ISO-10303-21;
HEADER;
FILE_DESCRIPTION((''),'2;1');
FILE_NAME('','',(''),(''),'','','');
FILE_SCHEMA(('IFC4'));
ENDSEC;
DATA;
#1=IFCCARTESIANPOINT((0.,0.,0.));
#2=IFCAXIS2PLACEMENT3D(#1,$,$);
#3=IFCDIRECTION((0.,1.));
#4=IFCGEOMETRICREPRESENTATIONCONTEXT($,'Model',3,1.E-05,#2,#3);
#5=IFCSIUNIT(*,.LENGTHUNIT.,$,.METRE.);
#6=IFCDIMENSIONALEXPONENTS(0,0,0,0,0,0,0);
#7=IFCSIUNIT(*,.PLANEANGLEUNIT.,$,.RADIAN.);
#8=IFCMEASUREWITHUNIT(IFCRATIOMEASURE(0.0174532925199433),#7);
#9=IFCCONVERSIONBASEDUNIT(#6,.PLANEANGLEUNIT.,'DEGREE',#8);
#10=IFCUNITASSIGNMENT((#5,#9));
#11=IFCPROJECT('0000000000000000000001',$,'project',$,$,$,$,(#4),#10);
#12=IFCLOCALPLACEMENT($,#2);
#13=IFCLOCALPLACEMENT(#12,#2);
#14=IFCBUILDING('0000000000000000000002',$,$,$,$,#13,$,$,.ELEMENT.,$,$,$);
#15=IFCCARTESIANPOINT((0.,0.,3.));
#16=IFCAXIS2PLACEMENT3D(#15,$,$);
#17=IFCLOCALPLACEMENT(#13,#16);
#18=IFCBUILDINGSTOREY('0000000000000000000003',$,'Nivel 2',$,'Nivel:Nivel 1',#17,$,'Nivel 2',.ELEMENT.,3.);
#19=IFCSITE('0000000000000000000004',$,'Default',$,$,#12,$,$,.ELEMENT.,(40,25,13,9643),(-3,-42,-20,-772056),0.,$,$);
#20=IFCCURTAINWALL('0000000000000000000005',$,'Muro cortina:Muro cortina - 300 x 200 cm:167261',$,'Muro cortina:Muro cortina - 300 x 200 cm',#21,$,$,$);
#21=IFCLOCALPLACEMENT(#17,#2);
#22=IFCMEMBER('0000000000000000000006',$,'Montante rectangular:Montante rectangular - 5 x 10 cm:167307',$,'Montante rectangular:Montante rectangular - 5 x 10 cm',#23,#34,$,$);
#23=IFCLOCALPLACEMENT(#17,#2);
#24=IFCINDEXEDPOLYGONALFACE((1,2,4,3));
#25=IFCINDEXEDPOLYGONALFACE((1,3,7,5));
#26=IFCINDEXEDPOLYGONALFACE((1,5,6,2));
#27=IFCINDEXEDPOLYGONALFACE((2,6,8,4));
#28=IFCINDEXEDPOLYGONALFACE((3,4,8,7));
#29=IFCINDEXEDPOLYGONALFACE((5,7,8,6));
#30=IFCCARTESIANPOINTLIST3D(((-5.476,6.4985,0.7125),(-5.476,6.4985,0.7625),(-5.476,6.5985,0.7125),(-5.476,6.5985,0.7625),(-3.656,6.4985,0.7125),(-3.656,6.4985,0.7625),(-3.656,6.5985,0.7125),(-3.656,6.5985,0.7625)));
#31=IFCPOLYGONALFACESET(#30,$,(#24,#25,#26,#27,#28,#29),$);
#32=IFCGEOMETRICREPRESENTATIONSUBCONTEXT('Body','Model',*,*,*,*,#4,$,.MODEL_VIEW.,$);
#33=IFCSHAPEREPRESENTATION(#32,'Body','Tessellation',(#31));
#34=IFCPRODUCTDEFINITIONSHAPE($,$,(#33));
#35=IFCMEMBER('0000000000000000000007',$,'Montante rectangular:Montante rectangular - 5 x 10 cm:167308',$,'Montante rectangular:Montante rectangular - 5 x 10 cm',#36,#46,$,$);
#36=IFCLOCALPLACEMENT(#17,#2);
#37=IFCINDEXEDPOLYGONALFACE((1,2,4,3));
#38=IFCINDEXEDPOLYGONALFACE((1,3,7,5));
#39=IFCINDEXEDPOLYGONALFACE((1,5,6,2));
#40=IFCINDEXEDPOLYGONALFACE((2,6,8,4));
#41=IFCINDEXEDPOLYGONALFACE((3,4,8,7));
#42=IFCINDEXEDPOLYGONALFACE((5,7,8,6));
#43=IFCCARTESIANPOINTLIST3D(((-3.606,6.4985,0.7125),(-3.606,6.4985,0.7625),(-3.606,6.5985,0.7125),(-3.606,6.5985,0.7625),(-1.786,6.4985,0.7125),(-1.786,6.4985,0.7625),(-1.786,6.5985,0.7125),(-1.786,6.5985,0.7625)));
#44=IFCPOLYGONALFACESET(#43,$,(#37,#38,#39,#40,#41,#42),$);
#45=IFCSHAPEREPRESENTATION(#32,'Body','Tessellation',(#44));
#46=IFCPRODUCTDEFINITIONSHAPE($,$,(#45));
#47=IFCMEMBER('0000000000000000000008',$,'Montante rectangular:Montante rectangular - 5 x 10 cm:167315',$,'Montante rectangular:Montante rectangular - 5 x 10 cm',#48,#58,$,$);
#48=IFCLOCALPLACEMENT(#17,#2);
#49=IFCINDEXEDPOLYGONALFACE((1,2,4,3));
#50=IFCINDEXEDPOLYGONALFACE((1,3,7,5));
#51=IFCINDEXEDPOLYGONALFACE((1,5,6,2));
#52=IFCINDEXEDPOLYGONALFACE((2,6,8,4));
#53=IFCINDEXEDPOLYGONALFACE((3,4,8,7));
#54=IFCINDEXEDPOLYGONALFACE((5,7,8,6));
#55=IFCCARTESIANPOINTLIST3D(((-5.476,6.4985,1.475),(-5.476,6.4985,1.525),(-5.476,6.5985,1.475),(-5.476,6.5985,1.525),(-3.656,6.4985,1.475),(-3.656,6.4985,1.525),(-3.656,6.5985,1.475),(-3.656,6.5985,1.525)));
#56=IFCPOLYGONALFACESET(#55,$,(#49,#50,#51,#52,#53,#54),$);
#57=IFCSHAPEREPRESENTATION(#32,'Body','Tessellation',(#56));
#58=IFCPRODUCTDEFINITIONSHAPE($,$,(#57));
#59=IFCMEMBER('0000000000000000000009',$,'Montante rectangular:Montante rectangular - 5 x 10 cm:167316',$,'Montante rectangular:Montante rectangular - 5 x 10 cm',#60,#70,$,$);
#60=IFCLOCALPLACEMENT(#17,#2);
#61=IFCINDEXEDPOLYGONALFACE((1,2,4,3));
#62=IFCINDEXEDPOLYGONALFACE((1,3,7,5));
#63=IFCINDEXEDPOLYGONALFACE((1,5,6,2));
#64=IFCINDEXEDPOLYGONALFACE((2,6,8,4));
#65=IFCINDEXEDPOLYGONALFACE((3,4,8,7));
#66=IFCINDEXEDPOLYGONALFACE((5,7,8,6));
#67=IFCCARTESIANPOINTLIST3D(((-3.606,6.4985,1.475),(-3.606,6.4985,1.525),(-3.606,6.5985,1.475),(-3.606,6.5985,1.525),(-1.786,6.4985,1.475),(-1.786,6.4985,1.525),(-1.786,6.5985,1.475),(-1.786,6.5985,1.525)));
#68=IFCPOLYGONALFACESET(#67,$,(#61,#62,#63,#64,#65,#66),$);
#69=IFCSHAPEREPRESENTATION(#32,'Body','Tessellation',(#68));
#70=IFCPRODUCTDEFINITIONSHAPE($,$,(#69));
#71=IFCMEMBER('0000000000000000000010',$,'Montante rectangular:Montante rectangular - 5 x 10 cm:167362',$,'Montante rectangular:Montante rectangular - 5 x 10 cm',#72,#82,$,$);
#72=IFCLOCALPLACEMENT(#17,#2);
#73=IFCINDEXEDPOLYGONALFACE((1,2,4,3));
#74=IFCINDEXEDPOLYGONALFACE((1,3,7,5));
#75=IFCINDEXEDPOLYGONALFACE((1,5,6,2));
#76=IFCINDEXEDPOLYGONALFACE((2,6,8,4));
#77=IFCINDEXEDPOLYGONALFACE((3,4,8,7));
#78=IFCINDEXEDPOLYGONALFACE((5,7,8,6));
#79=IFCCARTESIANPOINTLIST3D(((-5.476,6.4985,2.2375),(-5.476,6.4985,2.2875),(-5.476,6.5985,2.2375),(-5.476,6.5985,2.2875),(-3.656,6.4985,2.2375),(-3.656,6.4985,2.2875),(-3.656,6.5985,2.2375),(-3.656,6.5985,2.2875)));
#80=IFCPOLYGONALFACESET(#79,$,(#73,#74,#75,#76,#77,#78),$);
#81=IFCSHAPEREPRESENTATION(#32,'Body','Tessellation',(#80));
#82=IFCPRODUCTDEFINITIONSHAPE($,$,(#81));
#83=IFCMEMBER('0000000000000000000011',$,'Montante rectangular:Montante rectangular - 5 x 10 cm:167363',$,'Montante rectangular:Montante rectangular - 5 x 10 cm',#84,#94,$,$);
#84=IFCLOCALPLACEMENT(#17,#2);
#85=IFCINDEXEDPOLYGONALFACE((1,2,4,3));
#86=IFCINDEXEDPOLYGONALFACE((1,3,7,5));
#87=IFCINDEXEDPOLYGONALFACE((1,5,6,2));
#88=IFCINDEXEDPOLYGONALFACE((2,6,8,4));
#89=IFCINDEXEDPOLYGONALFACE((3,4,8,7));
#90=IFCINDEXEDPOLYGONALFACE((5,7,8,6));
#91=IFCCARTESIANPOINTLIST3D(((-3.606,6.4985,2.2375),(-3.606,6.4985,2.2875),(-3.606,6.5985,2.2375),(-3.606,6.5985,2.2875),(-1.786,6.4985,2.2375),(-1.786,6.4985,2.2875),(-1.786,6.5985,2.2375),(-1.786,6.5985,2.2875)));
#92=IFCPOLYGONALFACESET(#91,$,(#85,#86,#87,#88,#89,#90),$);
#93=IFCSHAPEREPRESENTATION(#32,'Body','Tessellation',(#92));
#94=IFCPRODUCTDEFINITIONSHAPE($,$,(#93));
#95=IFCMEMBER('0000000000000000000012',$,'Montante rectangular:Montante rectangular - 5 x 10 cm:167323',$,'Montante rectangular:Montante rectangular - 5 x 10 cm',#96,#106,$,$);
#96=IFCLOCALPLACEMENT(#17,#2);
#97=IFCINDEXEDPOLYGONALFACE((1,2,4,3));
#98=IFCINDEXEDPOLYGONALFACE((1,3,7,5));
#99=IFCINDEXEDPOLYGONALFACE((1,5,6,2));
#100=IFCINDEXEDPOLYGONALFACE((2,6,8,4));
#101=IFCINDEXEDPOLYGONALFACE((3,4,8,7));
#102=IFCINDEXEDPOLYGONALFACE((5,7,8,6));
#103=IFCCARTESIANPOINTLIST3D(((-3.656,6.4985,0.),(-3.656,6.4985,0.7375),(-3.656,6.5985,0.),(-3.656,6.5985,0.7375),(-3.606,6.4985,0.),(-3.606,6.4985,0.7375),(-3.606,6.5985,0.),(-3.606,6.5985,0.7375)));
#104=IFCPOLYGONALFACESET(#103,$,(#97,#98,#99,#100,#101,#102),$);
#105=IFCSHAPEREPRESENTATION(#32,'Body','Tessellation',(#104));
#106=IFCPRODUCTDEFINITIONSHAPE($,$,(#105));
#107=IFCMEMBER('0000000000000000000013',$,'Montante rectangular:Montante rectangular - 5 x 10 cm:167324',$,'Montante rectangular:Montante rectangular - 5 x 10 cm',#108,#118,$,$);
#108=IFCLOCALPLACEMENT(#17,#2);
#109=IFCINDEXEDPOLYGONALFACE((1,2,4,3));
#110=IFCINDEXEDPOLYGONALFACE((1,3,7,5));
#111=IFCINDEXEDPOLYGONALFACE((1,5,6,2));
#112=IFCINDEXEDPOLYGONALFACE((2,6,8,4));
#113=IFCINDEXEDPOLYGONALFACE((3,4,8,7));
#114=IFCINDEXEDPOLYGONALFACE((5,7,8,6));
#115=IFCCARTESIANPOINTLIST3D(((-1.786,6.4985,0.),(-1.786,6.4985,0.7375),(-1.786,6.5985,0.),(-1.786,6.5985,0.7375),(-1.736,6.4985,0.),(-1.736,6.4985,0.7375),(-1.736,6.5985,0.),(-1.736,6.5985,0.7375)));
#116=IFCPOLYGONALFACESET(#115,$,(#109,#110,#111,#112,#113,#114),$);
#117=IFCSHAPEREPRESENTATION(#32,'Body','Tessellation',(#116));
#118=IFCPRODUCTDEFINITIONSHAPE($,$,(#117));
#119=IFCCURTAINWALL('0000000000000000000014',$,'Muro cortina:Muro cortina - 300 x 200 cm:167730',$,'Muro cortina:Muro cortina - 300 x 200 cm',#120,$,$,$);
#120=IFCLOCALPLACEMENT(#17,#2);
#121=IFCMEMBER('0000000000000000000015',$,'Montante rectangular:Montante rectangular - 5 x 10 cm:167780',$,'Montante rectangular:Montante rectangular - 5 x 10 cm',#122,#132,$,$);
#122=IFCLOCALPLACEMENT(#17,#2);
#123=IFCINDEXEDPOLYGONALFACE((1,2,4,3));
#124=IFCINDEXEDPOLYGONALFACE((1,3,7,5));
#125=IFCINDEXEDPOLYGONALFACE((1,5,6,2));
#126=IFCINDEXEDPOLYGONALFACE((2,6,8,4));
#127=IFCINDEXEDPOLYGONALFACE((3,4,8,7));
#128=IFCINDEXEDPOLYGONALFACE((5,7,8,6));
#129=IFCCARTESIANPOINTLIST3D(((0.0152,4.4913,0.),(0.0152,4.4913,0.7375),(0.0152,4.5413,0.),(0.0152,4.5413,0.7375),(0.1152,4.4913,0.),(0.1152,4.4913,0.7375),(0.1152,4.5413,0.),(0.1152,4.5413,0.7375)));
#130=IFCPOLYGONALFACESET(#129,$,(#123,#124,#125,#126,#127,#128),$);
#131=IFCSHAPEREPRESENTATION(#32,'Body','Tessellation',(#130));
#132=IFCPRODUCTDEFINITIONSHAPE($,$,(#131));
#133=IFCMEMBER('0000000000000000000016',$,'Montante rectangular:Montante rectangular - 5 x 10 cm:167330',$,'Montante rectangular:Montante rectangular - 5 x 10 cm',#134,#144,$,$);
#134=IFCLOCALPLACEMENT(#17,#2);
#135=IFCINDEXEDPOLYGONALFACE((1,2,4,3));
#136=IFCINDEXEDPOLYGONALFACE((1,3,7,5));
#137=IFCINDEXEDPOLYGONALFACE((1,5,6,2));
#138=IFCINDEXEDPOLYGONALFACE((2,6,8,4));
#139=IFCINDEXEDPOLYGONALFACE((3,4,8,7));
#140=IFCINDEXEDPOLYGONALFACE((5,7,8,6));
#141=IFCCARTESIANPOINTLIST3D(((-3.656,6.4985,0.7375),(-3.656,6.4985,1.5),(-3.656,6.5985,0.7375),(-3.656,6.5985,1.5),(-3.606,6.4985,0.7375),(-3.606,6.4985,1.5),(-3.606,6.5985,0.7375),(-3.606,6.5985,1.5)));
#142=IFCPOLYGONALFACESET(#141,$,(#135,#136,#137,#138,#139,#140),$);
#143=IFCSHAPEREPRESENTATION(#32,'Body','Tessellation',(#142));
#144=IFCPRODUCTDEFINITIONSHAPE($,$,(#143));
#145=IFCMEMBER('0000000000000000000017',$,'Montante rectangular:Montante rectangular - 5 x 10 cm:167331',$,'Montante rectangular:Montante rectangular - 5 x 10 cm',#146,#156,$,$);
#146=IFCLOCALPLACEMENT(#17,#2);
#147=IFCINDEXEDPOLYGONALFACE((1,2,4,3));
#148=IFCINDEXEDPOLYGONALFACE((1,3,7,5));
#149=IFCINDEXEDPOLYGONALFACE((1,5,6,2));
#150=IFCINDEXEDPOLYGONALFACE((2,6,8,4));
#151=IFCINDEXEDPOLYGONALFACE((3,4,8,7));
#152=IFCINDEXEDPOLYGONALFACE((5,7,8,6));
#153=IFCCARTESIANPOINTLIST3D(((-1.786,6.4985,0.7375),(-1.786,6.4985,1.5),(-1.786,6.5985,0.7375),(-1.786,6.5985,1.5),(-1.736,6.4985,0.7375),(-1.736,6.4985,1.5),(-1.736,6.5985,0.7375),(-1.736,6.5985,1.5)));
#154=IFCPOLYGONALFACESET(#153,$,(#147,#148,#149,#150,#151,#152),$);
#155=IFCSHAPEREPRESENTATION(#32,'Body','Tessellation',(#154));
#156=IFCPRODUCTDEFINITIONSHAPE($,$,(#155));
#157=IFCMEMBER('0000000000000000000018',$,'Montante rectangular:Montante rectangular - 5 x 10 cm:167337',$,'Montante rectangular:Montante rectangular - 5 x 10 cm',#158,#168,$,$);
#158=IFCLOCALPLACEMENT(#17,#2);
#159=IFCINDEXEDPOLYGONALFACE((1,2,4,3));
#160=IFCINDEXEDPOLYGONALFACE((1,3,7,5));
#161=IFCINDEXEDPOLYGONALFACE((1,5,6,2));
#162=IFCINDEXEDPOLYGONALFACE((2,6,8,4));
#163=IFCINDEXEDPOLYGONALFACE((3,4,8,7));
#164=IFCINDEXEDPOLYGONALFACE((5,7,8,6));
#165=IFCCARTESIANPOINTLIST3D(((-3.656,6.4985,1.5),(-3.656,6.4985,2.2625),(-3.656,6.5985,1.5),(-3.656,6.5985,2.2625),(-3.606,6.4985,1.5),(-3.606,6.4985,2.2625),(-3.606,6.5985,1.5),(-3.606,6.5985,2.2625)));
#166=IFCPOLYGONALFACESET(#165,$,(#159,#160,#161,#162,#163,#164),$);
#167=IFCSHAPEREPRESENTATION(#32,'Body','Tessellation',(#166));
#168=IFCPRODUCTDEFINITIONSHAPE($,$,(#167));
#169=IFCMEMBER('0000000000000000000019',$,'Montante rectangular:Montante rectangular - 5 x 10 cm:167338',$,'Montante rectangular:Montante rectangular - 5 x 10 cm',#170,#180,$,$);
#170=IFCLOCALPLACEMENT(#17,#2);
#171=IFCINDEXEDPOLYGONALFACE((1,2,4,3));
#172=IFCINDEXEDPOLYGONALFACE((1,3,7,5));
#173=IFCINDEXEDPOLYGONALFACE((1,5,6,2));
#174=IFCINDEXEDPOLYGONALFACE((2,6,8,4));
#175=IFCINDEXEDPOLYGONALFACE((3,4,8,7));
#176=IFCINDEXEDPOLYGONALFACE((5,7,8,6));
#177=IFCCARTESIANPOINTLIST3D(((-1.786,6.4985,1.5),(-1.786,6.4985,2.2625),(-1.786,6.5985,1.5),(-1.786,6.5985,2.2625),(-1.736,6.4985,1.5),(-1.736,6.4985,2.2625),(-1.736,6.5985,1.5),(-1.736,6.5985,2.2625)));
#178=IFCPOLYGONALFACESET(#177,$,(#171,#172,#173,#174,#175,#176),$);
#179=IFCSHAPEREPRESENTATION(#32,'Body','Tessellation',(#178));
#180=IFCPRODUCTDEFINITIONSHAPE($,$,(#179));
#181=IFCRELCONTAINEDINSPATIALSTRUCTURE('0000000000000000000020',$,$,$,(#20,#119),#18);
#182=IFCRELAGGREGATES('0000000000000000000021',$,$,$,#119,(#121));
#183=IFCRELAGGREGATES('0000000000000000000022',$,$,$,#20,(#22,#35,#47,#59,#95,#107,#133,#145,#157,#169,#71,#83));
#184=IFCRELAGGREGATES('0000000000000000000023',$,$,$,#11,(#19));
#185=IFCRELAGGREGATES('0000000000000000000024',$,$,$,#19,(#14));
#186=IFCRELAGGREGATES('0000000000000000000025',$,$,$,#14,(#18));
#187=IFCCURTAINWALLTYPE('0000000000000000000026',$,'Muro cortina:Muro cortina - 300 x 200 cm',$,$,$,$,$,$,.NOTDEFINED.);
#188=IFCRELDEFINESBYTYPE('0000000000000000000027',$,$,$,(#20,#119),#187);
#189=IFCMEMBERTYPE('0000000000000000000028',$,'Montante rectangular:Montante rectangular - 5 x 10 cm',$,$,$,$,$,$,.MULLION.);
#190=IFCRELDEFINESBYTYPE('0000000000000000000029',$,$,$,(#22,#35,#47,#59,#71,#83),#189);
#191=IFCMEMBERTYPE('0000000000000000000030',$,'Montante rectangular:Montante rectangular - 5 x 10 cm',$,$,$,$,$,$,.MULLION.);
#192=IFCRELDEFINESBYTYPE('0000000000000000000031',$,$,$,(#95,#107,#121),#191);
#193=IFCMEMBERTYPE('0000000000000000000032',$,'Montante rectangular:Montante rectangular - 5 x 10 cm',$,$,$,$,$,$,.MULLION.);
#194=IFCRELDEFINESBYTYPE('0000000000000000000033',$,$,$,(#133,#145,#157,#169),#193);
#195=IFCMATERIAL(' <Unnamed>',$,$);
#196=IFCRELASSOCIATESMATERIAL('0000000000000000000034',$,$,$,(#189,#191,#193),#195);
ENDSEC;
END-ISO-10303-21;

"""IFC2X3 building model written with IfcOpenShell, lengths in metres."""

from ifc_helpers import new_model, entity, si_unit, converted_unit, direction, frame, origin, origin_2d_with_axis, place, context, subcontext, project, spatial, rectangle, extrude, source, transform, mapped, material, type_object, type_shapes, element, aggregate, save


model = new_model("IFC2X3")

# Units and contexts
model_context = context("Model", 3, precision=1e-05, world=origin(), true_north=direction((0.0, 1.0)))
body_context = subcontext(model_context, "Body", "Model", "MODEL_VIEW")
ifc_project = project(units=[si_unit("LENGTHUNIT", "METRE"), converted_unit("PLANEANGLEUNIT", "DEGREE", entity("IfcRatioMeasure", 0.0174532925199433), si_unit("PLANEANGLEUNIT", "RADIAN"), dimensions=[0, 0, 0, 0, 0, 0, 0])], contexts=[model_context])

# Site, building, storey
site_placement = place(None, origin())
site = spatial("IfcSite", under=ifc_project, at=site_placement, Name="Default", CompositionType="ELEMENT", RefLatitude=(40, 25, 13, 9643), RefLongitude=(-3, -42, -20, -772056), RefElevation=0.0)
building_placement = place(site_placement, origin())
building = spatial("IfcBuilding", under=site, at=building_placement, CompositionType="ELEMENT")
storey_placement = place(building_placement, frame((0.0, 0.0, 3.0)))
storey = spatial("IfcBuildingStorey", under=building, at=storey_placement, Name="Nivel 2", ObjectType="Nivel:Nivel 1", LongName="Nivel 2", CompositionType="ELEMENT", Elevation=3.0)

# Curtain wall, members
curtain_wall_type = type_object("IfcCurtainWallType", Name="Muro cortina:Muro cortina - 300 x 200 cm", PredefinedType="NOTDEFINED")
curtain_wall_1_placement = place(storey_placement, frame((0.0, 0.0, -3.0)))
curtain_wall_1 = element("IfcCurtainWall", 1, at=curtain_wall_1_placement, inside=storey, type_object=curtain_wall_type, Name="Muro cortina:Muro cortina - 300 x 200 cm:167261", ObjectType="Muro cortina:Muro cortina - 300 x 200 cm")
ifc_material_1 = material(Name=" <Unnamed>")
member_type_1 = type_object("IfcMemberType", Name="Montante rectangular:Montante rectangular - 5 x 10 cm", PredefinedType="MULLION", material=ifc_material_1)
shared_shape_1 = source(origin(), body_context, "Body", "SweptSolid", [
    extrude(rectangle(XDim=0.1, YDim=0.05, at=origin_2d_with_axis()), frame((0.0, 0.0, -1.82), z_axis=(0.0, 0.0, 1.0), x_axis=(0.0, -1.0, 0.0)), (0.0, 0.0, 1.0), 1.82),
])
type_shapes(member_type_1, [shared_shape_1])
member_1_placement = place(storey_placement, frame((-3.656, 6.5485, 0.7375), z_axis=(1.0, 0.0, 0.0), x_axis=(0.0, 0.0, 1.0)))
member_1 = element("IfcMember", 2, at=member_1_placement, type_object=member_type_1, Name="Montante rectangular:Montante rectangular - 5 x 10 cm:167307", ObjectType="Montante rectangular:Montante rectangular - 5 x 10 cm", context=body_context, shape_type="MappedRepresentation", body=[
    mapped(shared_shape_1, transform((0.0, 0.0, 0.0), scale=1.0)),
])
member_2_placement = place(storey_placement, frame((-1.786, 6.5485, 0.7375), z_axis=(1.0, 0.0, 0.0), x_axis=(0.0, 0.0, 1.0)))
member_2 = element("IfcMember", 3, at=member_2_placement, type_object=member_type_1, Name="Montante rectangular:Montante rectangular - 5 x 10 cm:167308", ObjectType="Montante rectangular:Montante rectangular - 5 x 10 cm", context=body_context, shape_type="MappedRepresentation", body=[
    mapped(shared_shape_1, transform((0.0, 0.0, 0.0), scale=1.0)),
])
member_3_placement = place(storey_placement, frame((-3.656, 6.5485, 1.5), z_axis=(1.0, 0.0, 0.0), x_axis=(0.0, 0.0, 1.0)))
member_3 = element("IfcMember", 4, at=member_3_placement, type_object=member_type_1, Name="Montante rectangular:Montante rectangular - 5 x 10 cm:167315", ObjectType="Montante rectangular:Montante rectangular - 5 x 10 cm", context=body_context, shape_type="MappedRepresentation", body=[
    mapped(shared_shape_1, transform((0.0, 0.0, 0.0), scale=1.0)),
])
member_4_placement = place(storey_placement, frame((-1.786, 6.5485, 1.5), z_axis=(1.0, 0.0, 0.0), x_axis=(0.0, 0.0, 1.0)))
member_4 = element("IfcMember", 5, at=member_4_placement, type_object=member_type_1, Name="Montante rectangular:Montante rectangular - 5 x 10 cm:167316", ObjectType="Montante rectangular:Montante rectangular - 5 x 10 cm", context=body_context, shape_type="MappedRepresentation", body=[
    mapped(shared_shape_1, transform((0.0, 0.0, 0.0), scale=1.0)),
])
member_5_placement = place(storey_placement, frame((-3.656, 6.5485, 2.2625), z_axis=(1.0, 0.0, 0.0), x_axis=(0.0, 0.0, 1.0)))
member_5 = element("IfcMember", 6, at=member_5_placement, type_object=member_type_1, Name="Montante rectangular:Montante rectangular - 5 x 10 cm:167362", ObjectType="Montante rectangular:Montante rectangular - 5 x 10 cm", context=body_context, shape_type="MappedRepresentation", body=[
    mapped(shared_shape_1, transform((0.0, 0.0, 0.0), scale=1.0)),
])
member_6_placement = place(storey_placement, frame((-1.786, 6.5485, 2.2625), z_axis=(1.0, 0.0, 0.0), x_axis=(0.0, 0.0, 1.0)))
member_6 = element("IfcMember", 7, at=member_6_placement, type_object=member_type_1, Name="Montante rectangular:Montante rectangular - 5 x 10 cm:167363", ObjectType="Montante rectangular:Montante rectangular - 5 x 10 cm", context=body_context, shape_type="MappedRepresentation", body=[
    mapped(shared_shape_1, transform((0.0, 0.0, 0.0), scale=1.0)),
])
member_type_2 = type_object("IfcMemberType", Name="Montante rectangular:Montante rectangular - 5 x 10 cm", PredefinedType="MULLION", material=ifc_material_1)
shared_shape_2 = source(origin(), body_context, "Body", "SweptSolid", [
    extrude(rectangle(XDim=0.1, YDim=0.05, at=origin_2d_with_axis()), frame((0.0, 0.0, -0.7375), z_axis=(0.0, 0.0, 1.0), x_axis=(0.0, -1.0, 0.0)), (0.0, 0.0, 1.0), 0.7375),
])
type_shapes(member_type_2, [shared_shape_2])
member_7_placement = place(storey_placement, frame((-3.631, 6.5485, 0.0), z_axis=(0.0, 0.0, -1.0), x_axis=(1.0, 0.0, 0.0)))
member_7 = element("IfcMember", 8, at=member_7_placement, type_object=member_type_2, Name="Montante rectangular:Montante rectangular - 5 x 10 cm:167323", ObjectType="Montante rectangular:Montante rectangular - 5 x 10 cm", context=body_context, shape_type="MappedRepresentation", body=[
    mapped(shared_shape_2, transform((0.0, 0.0, 0.0), scale=1.0)),
])
member_8_placement = place(storey_placement, frame((-1.761, 6.5485, 0.0), z_axis=(0.0, 0.0, -1.0), x_axis=(1.0, 0.0, 0.0)))
member_8 = element("IfcMember", 9, at=member_8_placement, type_object=member_type_2, Name="Montante rectangular:Montante rectangular - 5 x 10 cm:167324", ObjectType="Montante rectangular:Montante rectangular - 5 x 10 cm", context=body_context, shape_type="MappedRepresentation", body=[
    mapped(shared_shape_2, transform((0.0, 0.0, 0.0), scale=1.0)),
])

# Curtain wall, member
curtain_wall_2_placement = place(storey_placement, frame((0.0, 0.0, -3.0)))
curtain_wall_2 = element("IfcCurtainWall", 10, at=curtain_wall_2_placement, inside=storey, type_object=curtain_wall_type, Name="Muro cortina:Muro cortina - 300 x 200 cm:167730", ObjectType="Muro cortina:Muro cortina - 300 x 200 cm")
member_9_placement = place(storey_placement, frame((0.0652, 4.5163, 0.0), z_axis=(0.0, 0.0, -1.0), x_axis=(0.0, -1.0, 0.0)))
member_9 = element("IfcMember", 11, at=member_9_placement, type_object=member_type_2, Name="Montante rectangular:Montante rectangular - 5 x 10 cm:167780", ObjectType="Montante rectangular:Montante rectangular - 5 x 10 cm", context=body_context, shape_type="MappedRepresentation", body=[
    mapped(shared_shape_2, transform((0.0, 0.0, 0.0), scale=1.0)),
])

# Members
member_type_3 = type_object("IfcMemberType", Name="Montante rectangular:Montante rectangular - 5 x 10 cm", PredefinedType="MULLION", material=ifc_material_1)
shared_shape_3 = source(origin(), body_context, "Body", "SweptSolid", [
    extrude(rectangle(XDim=0.1, YDim=0.05, at=origin_2d_with_axis()), frame((0.0, 0.0, -0.7625), z_axis=(0.0, 0.0, 1.0), x_axis=(0.0, -1.0, 0.0)), (0.0, 0.0, 1.0), 0.7625),
])
type_shapes(member_type_3, [shared_shape_3])
member_10_placement = place(storey_placement, frame((-3.631, 6.5485, 0.7375), z_axis=(0.0, 0.0, -1.0), x_axis=(1.0, 0.0, 0.0)))
member_10 = element("IfcMember", 12, at=member_10_placement, type_object=member_type_3, Name="Montante rectangular:Montante rectangular - 5 x 10 cm:167330", ObjectType="Montante rectangular:Montante rectangular - 5 x 10 cm", context=body_context, shape_type="MappedRepresentation", body=[
    mapped(shared_shape_3, transform((0.0, 0.0, 0.0), scale=1.0)),
])
member_11_placement = place(storey_placement, frame((-1.761, 6.5485, 0.7375), z_axis=(0.0, 0.0, -1.0), x_axis=(1.0, 0.0, 0.0)))
member_11 = element("IfcMember", 13, at=member_11_placement, type_object=member_type_3, Name="Montante rectangular:Montante rectangular - 5 x 10 cm:167331", ObjectType="Montante rectangular:Montante rectangular - 5 x 10 cm", context=body_context, shape_type="MappedRepresentation", body=[
    mapped(shared_shape_3, transform((0.0, 0.0, 0.0), scale=1.0)),
])
member_12_placement = place(storey_placement, frame((-3.631, 6.5485, 1.5), z_axis=(0.0, 0.0, -1.0), x_axis=(1.0, 0.0, 0.0)))
member_12 = element("IfcMember", 14, at=member_12_placement, type_object=member_type_3, Name="Montante rectangular:Montante rectangular - 5 x 10 cm:167337", ObjectType="Montante rectangular:Montante rectangular - 5 x 10 cm", context=body_context, shape_type="MappedRepresentation", body=[
    mapped(shared_shape_3, transform((0.0, 0.0, 0.0), scale=1.0)),
])
member_13_placement = place(storey_placement, frame((-1.761, 6.5485, 1.5), z_axis=(0.0, 0.0, -1.0), x_axis=(1.0, 0.0, 0.0)))
member_13 = element("IfcMember", 15, at=member_13_placement, type_object=member_type_3, Name="Montante rectangular:Montante rectangular - 5 x 10 cm:167338", ObjectType="Montante rectangular:Montante rectangular - 5 x 10 cm", context=body_context, shape_type="MappedRepresentation", body=[
    mapped(shared_shape_3, transform((0.0, 0.0, 0.0), scale=1.0)),
])
aggregate(curtain_wall_2, [member_9])

aggregate(curtain_wall_1, [member_1, member_2, member_3, member_4, member_7, member_8, member_10, member_11, member_12, member_13, member_5, member_6])

save(model, "model.ifc")
